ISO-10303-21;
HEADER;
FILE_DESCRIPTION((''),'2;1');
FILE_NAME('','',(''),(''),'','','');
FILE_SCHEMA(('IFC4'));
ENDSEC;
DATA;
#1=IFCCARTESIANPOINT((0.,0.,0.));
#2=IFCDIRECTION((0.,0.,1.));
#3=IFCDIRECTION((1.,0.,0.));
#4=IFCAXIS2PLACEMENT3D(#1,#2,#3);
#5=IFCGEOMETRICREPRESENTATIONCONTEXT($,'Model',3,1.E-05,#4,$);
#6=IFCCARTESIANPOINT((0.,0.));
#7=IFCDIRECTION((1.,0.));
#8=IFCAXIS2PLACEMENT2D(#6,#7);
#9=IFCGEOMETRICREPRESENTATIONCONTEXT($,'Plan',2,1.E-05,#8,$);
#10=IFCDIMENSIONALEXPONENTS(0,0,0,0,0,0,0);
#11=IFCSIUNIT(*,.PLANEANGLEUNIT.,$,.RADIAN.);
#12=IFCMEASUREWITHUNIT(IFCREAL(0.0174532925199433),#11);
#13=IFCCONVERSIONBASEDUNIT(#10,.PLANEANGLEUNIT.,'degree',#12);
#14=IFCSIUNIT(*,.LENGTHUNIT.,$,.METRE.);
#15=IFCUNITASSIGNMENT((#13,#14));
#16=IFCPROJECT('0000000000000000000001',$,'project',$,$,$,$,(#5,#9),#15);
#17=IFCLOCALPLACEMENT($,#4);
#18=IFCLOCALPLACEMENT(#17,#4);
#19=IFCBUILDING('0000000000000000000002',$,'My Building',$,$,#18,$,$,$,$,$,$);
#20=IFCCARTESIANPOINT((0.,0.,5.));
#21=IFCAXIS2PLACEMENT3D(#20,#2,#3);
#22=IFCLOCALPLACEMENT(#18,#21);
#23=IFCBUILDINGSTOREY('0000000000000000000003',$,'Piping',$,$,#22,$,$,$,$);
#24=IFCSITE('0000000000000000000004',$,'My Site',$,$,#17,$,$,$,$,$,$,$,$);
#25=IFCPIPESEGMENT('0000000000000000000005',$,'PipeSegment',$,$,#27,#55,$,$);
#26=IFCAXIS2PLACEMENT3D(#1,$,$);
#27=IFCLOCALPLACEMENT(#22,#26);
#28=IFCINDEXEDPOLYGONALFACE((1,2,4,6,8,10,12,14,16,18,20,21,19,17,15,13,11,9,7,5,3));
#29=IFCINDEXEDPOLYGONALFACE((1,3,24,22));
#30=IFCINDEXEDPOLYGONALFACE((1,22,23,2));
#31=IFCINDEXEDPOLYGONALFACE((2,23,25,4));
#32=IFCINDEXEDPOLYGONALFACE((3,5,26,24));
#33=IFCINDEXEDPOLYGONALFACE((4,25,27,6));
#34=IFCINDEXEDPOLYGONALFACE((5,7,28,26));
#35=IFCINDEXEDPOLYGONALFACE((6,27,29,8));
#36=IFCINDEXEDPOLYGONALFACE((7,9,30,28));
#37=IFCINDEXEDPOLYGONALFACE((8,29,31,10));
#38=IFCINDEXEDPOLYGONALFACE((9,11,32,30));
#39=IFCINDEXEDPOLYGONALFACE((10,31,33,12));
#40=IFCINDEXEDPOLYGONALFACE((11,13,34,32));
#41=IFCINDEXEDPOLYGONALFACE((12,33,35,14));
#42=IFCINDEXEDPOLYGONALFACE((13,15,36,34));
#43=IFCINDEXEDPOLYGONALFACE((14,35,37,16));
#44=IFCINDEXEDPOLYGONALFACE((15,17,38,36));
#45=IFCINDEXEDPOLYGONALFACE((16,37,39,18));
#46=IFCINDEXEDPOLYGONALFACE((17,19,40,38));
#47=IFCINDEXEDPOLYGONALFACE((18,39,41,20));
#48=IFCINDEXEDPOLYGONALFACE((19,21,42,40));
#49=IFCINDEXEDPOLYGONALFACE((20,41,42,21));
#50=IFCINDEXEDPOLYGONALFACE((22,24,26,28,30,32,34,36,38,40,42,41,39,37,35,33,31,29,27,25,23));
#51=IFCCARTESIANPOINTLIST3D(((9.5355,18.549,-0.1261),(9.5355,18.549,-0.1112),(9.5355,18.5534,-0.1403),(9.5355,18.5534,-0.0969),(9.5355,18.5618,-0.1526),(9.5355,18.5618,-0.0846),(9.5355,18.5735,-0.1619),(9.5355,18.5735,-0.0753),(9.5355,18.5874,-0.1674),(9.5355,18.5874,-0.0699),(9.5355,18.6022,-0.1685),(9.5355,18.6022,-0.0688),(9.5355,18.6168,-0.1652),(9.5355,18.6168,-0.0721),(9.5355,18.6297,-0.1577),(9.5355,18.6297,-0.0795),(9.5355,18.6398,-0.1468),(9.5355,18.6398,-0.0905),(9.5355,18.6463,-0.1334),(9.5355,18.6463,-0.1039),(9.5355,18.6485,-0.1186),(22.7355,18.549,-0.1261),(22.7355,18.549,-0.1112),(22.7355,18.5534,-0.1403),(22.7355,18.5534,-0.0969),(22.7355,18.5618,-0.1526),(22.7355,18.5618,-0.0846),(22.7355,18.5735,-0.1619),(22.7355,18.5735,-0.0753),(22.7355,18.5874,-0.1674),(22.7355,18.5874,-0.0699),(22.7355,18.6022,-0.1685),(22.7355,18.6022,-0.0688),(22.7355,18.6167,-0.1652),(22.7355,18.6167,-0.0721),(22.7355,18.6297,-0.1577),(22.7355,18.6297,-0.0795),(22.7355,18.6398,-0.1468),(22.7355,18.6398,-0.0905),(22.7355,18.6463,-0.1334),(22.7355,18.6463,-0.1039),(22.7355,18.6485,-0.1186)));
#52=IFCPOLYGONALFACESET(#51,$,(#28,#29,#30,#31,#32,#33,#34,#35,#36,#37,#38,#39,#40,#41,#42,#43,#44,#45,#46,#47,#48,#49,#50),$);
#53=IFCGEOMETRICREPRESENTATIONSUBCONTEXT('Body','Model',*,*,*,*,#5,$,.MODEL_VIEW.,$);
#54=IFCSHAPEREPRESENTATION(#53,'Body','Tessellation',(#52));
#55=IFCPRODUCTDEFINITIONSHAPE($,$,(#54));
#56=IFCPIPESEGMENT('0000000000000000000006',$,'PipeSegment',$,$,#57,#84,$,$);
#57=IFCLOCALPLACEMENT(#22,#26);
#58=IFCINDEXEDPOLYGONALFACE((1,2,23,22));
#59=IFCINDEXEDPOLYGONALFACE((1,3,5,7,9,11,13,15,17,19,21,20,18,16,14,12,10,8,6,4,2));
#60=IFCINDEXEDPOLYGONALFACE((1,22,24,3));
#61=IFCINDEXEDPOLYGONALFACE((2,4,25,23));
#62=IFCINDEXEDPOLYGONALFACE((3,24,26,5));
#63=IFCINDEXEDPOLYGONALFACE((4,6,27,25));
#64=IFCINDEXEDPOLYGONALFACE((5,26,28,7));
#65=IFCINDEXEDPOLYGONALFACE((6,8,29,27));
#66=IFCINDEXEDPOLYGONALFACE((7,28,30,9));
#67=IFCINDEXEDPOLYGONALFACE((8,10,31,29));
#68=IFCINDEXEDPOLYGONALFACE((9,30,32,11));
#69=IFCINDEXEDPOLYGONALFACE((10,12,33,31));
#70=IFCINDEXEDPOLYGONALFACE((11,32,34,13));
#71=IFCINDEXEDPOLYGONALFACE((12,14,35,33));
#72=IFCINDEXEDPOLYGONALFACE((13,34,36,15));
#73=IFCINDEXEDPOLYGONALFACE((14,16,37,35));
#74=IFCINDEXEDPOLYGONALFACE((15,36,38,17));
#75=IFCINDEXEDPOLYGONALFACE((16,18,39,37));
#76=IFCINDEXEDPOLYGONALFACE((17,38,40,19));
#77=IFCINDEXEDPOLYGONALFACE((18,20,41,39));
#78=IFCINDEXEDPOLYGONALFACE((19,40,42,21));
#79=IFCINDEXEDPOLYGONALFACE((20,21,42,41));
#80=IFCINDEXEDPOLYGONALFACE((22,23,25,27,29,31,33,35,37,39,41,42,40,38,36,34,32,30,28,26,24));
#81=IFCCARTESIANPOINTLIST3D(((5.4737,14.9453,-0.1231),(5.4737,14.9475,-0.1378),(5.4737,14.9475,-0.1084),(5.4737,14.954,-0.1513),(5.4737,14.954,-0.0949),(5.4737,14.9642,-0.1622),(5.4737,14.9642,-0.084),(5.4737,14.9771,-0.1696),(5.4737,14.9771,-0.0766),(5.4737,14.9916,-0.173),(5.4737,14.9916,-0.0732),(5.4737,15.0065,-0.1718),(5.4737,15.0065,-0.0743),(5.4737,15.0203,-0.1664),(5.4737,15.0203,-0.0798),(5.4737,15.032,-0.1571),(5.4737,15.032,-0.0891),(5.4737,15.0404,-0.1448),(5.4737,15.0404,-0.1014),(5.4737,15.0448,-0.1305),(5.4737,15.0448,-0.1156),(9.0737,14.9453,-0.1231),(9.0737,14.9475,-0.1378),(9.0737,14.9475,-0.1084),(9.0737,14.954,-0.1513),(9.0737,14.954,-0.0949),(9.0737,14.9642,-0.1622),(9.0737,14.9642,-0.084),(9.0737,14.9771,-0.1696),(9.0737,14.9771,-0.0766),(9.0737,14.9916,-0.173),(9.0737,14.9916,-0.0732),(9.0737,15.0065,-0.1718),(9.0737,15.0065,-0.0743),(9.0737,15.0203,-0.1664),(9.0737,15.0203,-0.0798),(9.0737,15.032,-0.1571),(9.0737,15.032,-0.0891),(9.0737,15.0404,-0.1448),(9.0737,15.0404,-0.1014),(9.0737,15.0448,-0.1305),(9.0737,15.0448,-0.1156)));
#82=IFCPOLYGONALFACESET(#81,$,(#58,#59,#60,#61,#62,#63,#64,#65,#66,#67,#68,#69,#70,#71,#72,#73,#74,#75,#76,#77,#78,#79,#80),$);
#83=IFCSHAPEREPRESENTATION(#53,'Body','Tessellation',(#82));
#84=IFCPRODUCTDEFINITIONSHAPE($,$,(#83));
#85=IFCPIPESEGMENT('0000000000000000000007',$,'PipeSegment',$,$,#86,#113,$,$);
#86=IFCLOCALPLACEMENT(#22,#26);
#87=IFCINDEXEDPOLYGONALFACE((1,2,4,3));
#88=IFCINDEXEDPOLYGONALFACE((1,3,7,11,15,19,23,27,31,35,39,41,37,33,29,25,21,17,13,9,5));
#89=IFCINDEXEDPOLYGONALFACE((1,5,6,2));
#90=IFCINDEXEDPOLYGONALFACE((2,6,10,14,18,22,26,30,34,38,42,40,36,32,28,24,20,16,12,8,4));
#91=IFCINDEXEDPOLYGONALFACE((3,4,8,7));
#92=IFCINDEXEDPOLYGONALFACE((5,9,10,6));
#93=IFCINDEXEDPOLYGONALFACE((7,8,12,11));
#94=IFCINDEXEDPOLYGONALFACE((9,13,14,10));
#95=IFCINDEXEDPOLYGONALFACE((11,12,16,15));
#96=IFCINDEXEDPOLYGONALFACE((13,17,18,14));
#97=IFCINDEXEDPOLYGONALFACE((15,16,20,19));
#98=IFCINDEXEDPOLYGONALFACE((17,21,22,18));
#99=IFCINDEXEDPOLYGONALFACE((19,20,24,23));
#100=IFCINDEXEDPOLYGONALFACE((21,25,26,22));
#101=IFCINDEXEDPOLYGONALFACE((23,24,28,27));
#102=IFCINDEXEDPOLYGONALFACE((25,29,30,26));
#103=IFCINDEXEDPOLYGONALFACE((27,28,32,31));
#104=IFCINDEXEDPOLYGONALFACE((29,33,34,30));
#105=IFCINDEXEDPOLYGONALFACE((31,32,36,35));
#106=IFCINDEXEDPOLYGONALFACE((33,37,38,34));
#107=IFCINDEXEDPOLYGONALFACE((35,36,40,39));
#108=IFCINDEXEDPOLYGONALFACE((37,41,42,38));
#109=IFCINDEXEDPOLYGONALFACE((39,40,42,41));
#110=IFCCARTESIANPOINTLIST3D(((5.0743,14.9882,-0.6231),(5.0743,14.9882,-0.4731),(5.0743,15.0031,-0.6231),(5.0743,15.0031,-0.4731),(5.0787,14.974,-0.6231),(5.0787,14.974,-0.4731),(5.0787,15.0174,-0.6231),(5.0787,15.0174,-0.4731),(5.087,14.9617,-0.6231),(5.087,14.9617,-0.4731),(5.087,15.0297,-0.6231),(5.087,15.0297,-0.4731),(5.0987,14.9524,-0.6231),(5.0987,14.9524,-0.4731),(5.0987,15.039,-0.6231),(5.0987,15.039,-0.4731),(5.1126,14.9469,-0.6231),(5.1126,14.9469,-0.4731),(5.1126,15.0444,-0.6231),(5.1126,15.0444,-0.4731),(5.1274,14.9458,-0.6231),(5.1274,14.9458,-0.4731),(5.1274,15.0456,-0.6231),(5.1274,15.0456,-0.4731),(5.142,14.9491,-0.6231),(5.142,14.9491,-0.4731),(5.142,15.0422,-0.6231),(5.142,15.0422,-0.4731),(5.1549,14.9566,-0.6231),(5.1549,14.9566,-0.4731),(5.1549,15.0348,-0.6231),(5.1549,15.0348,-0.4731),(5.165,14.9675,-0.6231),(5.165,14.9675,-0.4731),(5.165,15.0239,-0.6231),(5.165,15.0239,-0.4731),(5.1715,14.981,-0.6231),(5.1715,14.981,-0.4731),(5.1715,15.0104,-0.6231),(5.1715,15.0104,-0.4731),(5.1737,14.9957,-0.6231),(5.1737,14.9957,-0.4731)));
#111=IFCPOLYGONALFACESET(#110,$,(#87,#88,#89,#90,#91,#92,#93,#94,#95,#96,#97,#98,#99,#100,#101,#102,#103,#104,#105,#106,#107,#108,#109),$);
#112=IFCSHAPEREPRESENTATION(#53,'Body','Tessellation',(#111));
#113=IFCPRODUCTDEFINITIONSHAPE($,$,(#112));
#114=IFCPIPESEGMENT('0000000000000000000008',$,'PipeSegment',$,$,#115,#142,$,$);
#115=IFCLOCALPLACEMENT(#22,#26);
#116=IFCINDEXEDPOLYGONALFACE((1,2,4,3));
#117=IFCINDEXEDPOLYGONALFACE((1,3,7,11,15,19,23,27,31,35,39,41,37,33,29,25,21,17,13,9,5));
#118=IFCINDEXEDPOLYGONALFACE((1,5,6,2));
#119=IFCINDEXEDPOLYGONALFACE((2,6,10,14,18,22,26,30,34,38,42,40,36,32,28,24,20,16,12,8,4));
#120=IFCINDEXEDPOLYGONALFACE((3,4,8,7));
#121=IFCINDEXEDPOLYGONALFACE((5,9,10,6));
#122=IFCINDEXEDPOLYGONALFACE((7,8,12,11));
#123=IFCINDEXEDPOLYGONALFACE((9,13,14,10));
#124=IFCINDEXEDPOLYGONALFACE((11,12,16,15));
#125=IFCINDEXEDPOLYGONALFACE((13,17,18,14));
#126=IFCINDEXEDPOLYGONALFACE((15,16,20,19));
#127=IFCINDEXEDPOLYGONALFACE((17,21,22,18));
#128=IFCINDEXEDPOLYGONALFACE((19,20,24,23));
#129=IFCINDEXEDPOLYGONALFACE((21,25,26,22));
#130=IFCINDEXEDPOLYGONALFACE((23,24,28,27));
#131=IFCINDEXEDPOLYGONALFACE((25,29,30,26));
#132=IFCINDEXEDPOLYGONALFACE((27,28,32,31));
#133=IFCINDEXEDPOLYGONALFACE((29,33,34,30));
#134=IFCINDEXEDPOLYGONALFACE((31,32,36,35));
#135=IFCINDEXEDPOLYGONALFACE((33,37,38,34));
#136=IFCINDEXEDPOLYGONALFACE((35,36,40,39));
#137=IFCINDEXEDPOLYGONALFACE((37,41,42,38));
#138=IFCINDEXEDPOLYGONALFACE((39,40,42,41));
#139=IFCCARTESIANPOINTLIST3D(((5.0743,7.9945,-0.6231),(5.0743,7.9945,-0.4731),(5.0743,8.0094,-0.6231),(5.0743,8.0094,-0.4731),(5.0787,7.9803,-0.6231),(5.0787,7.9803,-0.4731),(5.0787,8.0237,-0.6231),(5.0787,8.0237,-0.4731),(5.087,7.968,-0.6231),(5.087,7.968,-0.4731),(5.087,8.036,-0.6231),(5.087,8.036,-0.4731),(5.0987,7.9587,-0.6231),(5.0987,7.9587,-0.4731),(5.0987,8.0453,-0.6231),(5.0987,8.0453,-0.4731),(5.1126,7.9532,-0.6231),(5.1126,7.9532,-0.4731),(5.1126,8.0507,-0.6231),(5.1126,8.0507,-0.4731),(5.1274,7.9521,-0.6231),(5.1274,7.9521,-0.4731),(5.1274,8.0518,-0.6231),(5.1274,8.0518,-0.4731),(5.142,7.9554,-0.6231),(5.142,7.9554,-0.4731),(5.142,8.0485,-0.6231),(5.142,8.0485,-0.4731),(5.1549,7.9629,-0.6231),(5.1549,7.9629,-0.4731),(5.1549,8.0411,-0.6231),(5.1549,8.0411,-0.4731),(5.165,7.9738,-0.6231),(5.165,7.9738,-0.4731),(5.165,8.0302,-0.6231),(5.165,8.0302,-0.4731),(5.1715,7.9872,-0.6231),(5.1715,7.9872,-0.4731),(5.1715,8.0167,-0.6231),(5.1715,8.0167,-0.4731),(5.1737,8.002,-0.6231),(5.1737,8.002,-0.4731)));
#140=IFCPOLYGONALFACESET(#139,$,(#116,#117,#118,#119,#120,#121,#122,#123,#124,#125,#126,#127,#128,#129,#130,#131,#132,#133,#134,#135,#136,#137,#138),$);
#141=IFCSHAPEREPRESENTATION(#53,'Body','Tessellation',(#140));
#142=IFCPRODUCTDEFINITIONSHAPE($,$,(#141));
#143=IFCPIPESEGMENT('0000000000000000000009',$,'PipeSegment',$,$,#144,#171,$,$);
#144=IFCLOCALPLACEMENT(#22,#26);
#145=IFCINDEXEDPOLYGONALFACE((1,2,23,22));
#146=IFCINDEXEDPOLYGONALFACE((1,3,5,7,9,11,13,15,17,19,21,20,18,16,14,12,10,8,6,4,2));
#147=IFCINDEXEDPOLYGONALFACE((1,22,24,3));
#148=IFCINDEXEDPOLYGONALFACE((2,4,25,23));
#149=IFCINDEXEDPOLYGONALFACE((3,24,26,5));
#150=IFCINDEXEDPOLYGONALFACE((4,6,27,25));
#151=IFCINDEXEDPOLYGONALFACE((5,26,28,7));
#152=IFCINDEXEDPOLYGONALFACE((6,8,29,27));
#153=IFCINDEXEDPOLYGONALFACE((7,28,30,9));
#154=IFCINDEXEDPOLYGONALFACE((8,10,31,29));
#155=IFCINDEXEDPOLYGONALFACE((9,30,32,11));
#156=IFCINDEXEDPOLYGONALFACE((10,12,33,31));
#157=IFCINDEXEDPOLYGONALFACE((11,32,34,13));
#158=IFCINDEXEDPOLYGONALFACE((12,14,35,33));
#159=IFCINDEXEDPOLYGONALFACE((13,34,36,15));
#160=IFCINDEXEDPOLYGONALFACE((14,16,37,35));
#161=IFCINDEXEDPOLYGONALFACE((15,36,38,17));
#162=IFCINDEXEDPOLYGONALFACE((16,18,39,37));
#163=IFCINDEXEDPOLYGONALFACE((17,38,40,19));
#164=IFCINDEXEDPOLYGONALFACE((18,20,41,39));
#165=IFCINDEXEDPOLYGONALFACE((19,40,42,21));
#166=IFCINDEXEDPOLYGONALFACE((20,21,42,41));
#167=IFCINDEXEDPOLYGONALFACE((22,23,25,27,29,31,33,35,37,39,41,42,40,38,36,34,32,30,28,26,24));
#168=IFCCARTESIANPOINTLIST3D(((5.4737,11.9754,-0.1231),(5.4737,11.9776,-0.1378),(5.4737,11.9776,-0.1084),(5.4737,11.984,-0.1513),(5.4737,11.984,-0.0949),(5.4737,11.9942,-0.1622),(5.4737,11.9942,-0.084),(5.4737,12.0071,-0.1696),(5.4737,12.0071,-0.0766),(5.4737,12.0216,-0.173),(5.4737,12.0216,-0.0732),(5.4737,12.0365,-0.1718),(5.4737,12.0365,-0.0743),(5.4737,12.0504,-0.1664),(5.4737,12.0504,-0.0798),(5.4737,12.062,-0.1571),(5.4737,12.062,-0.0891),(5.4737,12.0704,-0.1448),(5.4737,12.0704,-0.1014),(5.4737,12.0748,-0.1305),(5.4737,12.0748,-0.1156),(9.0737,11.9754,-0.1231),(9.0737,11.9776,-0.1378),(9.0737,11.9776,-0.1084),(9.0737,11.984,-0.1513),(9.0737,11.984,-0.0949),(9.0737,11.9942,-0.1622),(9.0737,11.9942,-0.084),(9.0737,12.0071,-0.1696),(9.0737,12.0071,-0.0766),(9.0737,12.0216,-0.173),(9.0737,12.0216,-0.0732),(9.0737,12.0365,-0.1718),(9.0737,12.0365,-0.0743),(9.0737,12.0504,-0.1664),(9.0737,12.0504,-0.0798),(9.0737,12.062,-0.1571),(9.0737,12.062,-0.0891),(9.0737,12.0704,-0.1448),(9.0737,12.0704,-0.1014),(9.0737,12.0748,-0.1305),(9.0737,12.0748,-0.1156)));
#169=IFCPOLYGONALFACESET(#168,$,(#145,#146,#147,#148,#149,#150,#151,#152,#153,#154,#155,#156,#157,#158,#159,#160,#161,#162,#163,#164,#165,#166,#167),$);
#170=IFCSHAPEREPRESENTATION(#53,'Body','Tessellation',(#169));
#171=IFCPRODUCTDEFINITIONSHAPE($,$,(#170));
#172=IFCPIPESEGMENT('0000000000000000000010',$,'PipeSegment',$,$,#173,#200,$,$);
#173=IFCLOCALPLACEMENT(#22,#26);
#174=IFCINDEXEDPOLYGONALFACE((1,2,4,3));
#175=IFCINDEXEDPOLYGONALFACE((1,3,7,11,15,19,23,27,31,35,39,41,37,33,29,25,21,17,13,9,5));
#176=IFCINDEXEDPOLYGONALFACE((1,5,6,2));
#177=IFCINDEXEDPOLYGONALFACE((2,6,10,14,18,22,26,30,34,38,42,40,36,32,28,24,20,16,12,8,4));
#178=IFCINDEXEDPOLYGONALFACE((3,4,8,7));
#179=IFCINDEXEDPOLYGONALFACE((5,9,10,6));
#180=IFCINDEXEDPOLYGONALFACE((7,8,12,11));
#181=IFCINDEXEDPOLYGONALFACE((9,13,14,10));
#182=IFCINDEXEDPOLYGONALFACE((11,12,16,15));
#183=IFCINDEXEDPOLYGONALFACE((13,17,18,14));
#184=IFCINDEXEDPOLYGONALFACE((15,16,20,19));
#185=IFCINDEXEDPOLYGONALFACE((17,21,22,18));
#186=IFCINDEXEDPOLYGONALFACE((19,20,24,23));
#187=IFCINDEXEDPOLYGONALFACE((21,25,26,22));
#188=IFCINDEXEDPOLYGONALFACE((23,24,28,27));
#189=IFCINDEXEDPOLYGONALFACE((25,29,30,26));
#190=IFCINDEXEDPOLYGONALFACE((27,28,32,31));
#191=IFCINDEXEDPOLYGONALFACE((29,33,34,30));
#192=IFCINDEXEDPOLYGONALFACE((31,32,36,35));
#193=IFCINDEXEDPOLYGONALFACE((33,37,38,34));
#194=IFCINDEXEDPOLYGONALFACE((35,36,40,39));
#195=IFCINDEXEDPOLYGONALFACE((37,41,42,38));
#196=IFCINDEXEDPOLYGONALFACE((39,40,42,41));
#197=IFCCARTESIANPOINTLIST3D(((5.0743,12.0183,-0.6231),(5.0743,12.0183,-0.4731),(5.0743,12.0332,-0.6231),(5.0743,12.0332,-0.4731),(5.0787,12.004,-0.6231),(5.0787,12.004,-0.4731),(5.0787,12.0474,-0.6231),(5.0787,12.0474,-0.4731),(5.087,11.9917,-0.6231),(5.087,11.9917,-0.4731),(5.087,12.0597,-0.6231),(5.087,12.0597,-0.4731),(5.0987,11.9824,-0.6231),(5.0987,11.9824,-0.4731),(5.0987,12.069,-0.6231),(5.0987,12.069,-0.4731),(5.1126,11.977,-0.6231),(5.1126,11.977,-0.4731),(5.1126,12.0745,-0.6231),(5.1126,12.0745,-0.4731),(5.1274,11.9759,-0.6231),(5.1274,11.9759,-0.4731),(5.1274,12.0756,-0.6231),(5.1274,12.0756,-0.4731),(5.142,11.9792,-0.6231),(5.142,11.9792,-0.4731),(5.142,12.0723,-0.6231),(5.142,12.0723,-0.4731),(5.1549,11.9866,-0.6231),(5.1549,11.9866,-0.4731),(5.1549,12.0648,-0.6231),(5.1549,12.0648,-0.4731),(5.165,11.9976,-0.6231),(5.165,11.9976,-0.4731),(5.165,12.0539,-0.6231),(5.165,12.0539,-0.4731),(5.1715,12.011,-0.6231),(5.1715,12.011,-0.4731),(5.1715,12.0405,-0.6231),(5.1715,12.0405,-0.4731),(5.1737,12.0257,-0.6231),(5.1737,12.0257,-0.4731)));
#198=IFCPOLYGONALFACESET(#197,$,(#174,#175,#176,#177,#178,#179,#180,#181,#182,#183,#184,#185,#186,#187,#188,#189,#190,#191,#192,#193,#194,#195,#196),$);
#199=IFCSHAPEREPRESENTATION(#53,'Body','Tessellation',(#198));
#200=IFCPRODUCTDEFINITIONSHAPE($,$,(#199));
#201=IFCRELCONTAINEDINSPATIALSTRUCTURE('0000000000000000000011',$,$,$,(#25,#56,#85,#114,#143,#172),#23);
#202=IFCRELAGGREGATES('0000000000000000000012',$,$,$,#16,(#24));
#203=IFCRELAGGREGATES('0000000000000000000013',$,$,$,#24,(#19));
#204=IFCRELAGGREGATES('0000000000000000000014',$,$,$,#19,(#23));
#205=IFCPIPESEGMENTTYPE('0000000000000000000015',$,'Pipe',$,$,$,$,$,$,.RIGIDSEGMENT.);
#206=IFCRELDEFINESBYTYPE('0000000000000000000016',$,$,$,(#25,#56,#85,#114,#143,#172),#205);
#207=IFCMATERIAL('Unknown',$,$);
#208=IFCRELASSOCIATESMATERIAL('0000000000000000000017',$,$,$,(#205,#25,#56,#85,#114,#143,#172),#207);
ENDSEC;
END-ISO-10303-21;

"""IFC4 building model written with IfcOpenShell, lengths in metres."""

from ifc_helpers import new_model, entity, si_unit, converted_unit, frame, origin_with_axes, origin_2d_with_axis, place, context, subcontext, project, spatial, circle, extrude, material, material_profile, profile_set, profile_usage, type_object, element, save


model = new_model("IFC4")

# Units and contexts
model_context = context("Model", 3, precision=1e-05, world=origin_with_axes())
plan_context = context("Plan", 2, precision=1e-05, world=origin_2d_with_axis())
body_context = subcontext(model_context, "Body", "Model", "MODEL_VIEW")
ifc_project = project(units=[converted_unit("PLANEANGLEUNIT", "degree", entity("IfcReal", 0.0174532925199433), si_unit("PLANEANGLEUNIT", "RADIAN"), dimensions=[0, 0, 0, 0, 0, 0, 0]), si_unit("LENGTHUNIT", "METRE")], contexts=[model_context, plan_context])

# Site, building, storey
site_placement = place(None, origin_with_axes())
site = spatial("IfcSite", under=ifc_project, at=site_placement, Name="My Site")
building_placement = place(site_placement, origin_with_axes())
building = spatial("IfcBuilding", under=site, at=building_placement, Name="My Building")
storey_placement = place(building_placement, frame((0.0, 0.0, 5.0), z_axis=(0.0, 0.0, 1.0), x_axis=(1.0, 0.0, 0.0)))
storey = spatial("IfcBuildingStorey", under=building, at=storey_placement, Name="Piping")

# Pipe segments
ifc_material = material(Name="Unknown")
ifc_material_profile_1 = material_profile(ifc_material, circle(Radius=0.05))
ifc_profile_set_1 = profile_set([ifc_material_profile_1])
ifc_profile_usage_1 = profile_usage(ifc_profile_set_1, cardinal=5)
pipe_segment_type = type_object("IfcPipeSegmentType", Name="Pipe", PredefinedType="RIGIDSEGMENT", material=ifc_profile_set_1)
pipe_segment_1_placement = place(storey_placement, frame((9.5355, 18.5985, -0.1186), z_axis=(1.0, -0.000001, 0.000001), x_axis=(0.000001, 1.0, 0.0)))
element("IfcPipeSegment", 1, at=pipe_segment_1_placement, inside=storey, type_object=pipe_segment_type, material=ifc_profile_usage_1, Name="PipeSegment", context=body_context, shape_type="SweptSolid", body=[
    extrude(circle(Radius=0.05), origin_with_axes(), (0.0, 0.0, 1.0), 13.2),
])
ifc_profile_usage_2 = profile_usage(ifc_profile_set_1, cardinal=5)
pipe_segment_2_placement = place(storey_placement, frame((9.0737, 14.9953, -0.1231), z_axis=(-1.0, 0.0, 0.0), x_axis=(0.0, -1.0, 0.0)))
element("IfcPipeSegment", 2, at=pipe_segment_2_placement, inside=storey, type_object=pipe_segment_type, material=ifc_profile_usage_2, Name="PipeSegment", context=body_context, shape_type="SweptSolid", body=[
    extrude(circle(Radius=0.05), origin_with_axes(), (0.0, 0.0, 1.0), 3.6),
])
ifc_profile_usage_3 = profile_usage(ifc_profile_set_1, cardinal=5)
pipe_segment_3_placement = place(storey_placement, frame((5.1237, 14.9957, -0.4731), z_axis=(0.0, 0.0, -1.0), x_axis=(1.0, 0.0, 0.0)))
element("IfcPipeSegment", 3, at=pipe_segment_3_placement, inside=storey, type_object=pipe_segment_type, material=ifc_profile_usage_3, Name="PipeSegment", context=body_context, shape_type="SweptSolid", body=[
    extrude(circle(Radius=0.05), origin_with_axes(), (0.0, 0.0, 1.0), 0.15),
])
ifc_profile_usage_4 = profile_usage(ifc_profile_set_1, cardinal=5)
pipe_segment_4_placement = place(storey_placement, frame((5.1237, 8.002, -0.4731), z_axis=(0.0, 0.0, -1.0), x_axis=(1.0, 0.0, 0.0)))
element("IfcPipeSegment", 4, at=pipe_segment_4_placement, inside=storey, type_object=pipe_segment_type, material=ifc_profile_usage_4, Name="PipeSegment", context=body_context, shape_type="SweptSolid", body=[
    extrude(circle(Radius=0.05), origin_with_axes(), (0.0, 0.0, 1.0), 0.15),
])
ifc_profile_usage_5 = profile_usage(ifc_profile_set_1, cardinal=5)
pipe_segment_5_placement = place(storey_placement, frame((9.0737, 12.0254, -0.1231), z_axis=(-1.0, 0.0, 0.0), x_axis=(0.0, -1.0, 0.0)))
element("IfcPipeSegment", 5, at=pipe_segment_5_placement, inside=storey, type_object=pipe_segment_type, material=ifc_profile_usage_5, Name="PipeSegment", context=body_context, shape_type="SweptSolid", body=[
    extrude(circle(Radius=0.05), origin_with_axes(), (0.0, 0.0, 1.0), 3.6),
])
ifc_profile_usage_6 = profile_usage(ifc_profile_set_1, cardinal=5)
pipe_segment_6_placement = place(storey_placement, frame((5.1237, 12.0257, -0.4731), z_axis=(0.0, 0.0, -1.0), x_axis=(1.0, 0.0, 0.0)))
element("IfcPipeSegment", 6, at=pipe_segment_6_placement, inside=storey, type_object=pipe_segment_type, material=ifc_profile_usage_6, Name="PipeSegment", context=body_context, shape_type="SweptSolid", body=[
    extrude(circle(Radius=0.05), origin_with_axes(), (0.0, 0.0, 1.0), 0.15),
])

save(model, "model.ifc")
